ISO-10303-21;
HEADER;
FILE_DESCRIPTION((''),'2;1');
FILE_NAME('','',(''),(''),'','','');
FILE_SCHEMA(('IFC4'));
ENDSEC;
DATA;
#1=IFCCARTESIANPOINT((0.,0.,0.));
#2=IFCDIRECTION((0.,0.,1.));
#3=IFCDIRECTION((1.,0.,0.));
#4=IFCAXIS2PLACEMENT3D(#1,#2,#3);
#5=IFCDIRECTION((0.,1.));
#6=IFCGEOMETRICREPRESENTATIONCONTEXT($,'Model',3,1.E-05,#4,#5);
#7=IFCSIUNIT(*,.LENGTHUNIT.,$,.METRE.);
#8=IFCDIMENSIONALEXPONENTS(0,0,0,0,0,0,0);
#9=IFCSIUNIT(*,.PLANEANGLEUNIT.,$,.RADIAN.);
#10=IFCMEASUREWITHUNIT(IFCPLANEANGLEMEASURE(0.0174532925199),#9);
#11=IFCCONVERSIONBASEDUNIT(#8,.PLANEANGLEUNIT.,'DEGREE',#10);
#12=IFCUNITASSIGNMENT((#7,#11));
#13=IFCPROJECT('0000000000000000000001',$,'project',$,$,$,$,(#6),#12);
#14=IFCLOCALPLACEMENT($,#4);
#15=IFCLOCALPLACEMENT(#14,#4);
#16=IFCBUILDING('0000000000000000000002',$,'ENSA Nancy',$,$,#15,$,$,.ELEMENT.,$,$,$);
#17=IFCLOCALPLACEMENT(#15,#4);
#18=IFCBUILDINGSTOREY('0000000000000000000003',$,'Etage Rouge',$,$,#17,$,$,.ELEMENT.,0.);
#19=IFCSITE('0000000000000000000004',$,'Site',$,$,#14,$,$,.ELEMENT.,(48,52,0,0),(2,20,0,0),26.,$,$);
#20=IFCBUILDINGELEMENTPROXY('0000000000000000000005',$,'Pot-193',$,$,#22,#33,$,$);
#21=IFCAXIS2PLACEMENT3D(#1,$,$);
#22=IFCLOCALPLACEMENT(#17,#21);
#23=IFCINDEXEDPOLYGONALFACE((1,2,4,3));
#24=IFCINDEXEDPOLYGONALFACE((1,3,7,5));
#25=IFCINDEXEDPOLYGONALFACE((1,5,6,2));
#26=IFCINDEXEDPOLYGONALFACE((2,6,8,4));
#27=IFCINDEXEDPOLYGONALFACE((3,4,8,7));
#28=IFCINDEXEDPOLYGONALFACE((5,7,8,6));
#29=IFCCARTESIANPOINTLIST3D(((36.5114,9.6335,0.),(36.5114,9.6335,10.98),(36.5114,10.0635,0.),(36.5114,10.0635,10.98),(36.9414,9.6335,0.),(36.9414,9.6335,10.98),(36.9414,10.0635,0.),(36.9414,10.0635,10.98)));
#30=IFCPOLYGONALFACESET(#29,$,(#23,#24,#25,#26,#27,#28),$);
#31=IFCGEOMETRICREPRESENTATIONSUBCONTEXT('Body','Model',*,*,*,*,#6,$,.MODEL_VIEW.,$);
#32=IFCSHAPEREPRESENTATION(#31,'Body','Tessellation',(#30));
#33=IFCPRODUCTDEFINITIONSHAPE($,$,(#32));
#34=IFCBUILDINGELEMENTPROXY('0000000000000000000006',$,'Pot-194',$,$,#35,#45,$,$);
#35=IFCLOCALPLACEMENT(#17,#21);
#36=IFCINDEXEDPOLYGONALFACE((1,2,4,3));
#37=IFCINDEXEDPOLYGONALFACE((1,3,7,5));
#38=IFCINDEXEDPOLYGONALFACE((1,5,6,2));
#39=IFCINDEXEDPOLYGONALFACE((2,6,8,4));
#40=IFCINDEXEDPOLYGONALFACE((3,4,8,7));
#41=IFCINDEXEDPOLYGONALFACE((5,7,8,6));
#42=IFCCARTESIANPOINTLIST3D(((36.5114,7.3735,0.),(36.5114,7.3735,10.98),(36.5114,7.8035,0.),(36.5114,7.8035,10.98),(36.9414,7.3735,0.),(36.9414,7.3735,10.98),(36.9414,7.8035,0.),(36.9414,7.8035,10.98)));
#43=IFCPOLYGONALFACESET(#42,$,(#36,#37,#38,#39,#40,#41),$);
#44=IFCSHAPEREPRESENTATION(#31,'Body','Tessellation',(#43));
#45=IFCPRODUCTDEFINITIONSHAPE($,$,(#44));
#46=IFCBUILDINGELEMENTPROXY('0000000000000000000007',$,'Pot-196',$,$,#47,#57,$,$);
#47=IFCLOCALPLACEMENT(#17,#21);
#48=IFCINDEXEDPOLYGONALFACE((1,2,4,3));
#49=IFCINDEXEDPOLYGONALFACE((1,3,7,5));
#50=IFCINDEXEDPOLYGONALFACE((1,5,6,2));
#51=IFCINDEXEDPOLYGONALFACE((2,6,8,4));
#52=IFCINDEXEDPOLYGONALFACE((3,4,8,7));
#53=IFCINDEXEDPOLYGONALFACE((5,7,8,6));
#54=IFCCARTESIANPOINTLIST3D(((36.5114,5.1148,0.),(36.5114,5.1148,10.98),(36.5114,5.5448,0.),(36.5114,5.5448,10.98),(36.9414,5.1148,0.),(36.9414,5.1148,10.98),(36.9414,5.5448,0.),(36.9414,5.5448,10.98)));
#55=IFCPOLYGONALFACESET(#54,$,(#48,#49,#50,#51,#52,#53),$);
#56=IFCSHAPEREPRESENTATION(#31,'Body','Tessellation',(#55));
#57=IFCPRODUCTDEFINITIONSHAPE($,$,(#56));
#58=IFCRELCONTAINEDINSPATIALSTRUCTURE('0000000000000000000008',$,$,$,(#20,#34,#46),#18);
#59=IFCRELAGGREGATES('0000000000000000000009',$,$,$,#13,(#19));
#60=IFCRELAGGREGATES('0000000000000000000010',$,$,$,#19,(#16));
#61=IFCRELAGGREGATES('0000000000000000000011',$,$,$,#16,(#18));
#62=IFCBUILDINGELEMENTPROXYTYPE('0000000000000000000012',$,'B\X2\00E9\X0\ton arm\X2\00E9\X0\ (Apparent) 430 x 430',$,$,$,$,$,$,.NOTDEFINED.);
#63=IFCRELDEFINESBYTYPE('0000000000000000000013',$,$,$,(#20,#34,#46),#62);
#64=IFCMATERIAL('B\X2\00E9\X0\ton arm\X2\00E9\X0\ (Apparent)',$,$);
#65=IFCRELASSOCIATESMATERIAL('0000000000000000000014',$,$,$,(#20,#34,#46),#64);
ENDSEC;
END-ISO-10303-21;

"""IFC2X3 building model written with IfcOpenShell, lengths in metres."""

from ifc_helpers import new_model, entity, si_unit, converted_unit, direction, frame, origin_with_axes, origin_2d_with_axis, place, context, subcontext, project, spatial, rectangle, extrude, material, type_object, element, save


model = new_model("IFC2X3")

# Units and contexts
model_context = context("Model", 3, precision=1e-05, world=origin_with_axes(), true_north=direction((0.0, 1.0)))
body_context = subcontext(model_context, "Body", "Model", "MODEL_VIEW")
ifc_project = project(units=[si_unit("LENGTHUNIT", "METRE"), converted_unit("PLANEANGLEUNIT", "DEGREE", entity("IfcPlaneAngleMeasure", 0.0174532925199), si_unit("PLANEANGLEUNIT", "RADIAN"), dimensions=[0, 0, 0, 0, 0, 0, 0])], contexts=[model_context])

# Site, building, storey
site_placement = place(None, origin_with_axes())
site = spatial("IfcSite", under=ifc_project, at=site_placement, Name="Site", CompositionType="ELEMENT", RefLatitude=(48, 52, 0, 0), RefLongitude=(2, 20, 0, 0), RefElevation=26.0)
building_placement = place(site_placement, origin_with_axes())
building = spatial("IfcBuilding", under=site, at=building_placement, Name="ENSA Nancy", CompositionType="ELEMENT")
storey_placement = place(building_placement, origin_with_axes())
storey = spatial("IfcBuildingStorey", under=building, at=storey_placement, Name="Etage Rouge", CompositionType="ELEMENT", Elevation=0.0)

# Building element proxies
ifc_material_1 = material(Name="Béton armé (Apparent)")
building_element_proxy_type_1 = type_object("IfcBuildingElementProxyType", Name="Béton armé (Apparent) 430 x 430", PredefinedType="NOTDEFINED")
for number, where, z_axis, x_axis, name in (
    (1, (36.7264, 9.8485, 0.0), (0.0, 0.0, 1.0), (1.0, 0.0, 0.0), "Pot-193"),
    (2, (36.7264, 7.5885, 0.0), (0.0, 0.0, 1.0), (1.0, 0.0, 0.0), "Pot-194"),
    (3, (36.7264, 5.3298, 0.0), (0.0, 0.0, 1.0), (1.0, 0.0, 0.0), "Pot-196"),
):
    element("IfcBuildingElementProxy", number, at=place(storey_placement, frame(where, z_axis=z_axis, x_axis=x_axis)), inside=storey, type_object=building_element_proxy_type_1, material=ifc_material_1, Name=name, context=body_context, shape_type="SweptSolid", body=[
        extrude(rectangle(XDim=0.43, YDim=0.43, at=origin_2d_with_axis()), origin_with_axes(), (0.0, 0.0, 1.0), 10.98),
    ])

save(model, "model.ifc")
